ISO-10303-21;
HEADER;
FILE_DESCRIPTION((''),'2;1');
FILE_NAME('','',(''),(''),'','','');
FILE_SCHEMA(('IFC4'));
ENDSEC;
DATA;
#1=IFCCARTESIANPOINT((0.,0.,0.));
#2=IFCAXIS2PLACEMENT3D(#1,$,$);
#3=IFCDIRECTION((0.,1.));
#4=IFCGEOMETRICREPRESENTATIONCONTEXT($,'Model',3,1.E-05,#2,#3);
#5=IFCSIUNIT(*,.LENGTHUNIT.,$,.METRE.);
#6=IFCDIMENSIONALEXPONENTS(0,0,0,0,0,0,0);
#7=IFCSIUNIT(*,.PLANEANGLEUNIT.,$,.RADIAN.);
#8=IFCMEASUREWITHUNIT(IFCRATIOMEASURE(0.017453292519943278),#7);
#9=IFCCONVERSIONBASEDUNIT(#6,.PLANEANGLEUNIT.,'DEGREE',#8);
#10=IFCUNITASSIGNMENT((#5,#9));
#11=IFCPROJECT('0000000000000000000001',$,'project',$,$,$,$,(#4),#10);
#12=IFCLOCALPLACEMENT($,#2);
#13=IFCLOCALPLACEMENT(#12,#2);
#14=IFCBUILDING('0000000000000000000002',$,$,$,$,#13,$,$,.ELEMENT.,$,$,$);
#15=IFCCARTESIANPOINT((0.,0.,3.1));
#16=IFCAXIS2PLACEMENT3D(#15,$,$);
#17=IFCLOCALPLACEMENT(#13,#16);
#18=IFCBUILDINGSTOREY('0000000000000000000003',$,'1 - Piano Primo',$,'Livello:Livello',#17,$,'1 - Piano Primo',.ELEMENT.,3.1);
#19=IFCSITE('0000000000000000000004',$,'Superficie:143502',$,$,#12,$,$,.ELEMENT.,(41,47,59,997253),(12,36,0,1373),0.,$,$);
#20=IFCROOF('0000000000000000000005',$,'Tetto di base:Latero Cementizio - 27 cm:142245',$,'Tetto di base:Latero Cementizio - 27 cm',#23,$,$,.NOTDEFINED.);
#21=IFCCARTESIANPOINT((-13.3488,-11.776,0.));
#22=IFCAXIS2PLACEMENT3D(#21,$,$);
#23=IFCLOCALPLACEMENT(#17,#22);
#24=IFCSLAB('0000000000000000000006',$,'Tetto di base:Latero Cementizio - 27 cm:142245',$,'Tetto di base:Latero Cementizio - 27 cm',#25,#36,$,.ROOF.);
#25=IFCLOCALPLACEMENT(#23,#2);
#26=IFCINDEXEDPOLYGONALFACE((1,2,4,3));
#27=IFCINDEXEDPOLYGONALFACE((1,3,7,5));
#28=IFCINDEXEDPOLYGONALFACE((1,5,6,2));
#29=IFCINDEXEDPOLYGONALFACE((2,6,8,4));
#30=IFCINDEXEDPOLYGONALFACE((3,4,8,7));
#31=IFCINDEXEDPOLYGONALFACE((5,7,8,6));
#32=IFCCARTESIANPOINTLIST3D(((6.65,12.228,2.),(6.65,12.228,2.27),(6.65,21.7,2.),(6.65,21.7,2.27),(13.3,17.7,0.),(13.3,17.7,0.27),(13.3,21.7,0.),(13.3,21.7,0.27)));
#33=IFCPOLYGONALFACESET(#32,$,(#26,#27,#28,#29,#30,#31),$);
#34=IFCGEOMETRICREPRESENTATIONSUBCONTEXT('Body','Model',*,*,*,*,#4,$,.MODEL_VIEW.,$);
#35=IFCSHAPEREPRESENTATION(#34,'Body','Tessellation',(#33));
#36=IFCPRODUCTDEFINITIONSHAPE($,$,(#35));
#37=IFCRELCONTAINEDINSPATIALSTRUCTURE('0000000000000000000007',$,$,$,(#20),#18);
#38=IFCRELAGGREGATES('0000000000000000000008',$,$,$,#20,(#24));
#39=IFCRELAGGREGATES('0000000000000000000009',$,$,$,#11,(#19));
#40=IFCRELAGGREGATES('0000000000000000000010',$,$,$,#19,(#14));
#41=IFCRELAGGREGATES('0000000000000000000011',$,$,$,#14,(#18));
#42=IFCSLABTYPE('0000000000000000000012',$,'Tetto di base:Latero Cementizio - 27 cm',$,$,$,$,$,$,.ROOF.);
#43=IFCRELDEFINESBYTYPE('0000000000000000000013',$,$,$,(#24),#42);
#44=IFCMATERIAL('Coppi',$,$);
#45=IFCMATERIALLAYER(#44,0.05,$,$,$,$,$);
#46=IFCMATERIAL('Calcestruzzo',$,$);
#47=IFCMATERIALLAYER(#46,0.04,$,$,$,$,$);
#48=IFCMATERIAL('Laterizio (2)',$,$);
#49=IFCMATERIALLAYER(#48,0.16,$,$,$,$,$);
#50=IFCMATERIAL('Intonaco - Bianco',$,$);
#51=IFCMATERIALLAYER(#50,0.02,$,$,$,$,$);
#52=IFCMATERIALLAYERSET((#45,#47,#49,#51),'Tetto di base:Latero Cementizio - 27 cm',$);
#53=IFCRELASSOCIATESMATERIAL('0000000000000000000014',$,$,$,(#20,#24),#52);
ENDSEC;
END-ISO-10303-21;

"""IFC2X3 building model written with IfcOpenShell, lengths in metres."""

from ifc_helpers import new_model, entity, si_unit, converted_unit, direction, frame, origin, place, context, subcontext, project, spatial, polyline, outline, extrude, material, layer, layer_set, type_object, element, aggregate, save


model = new_model("IFC2X3")

# Units and contexts
model_context = context("Model", 3, precision=1e-05, world=origin(), true_north=direction((0.0, 1.0)))
body_context = subcontext(model_context, "Body", "Model", "MODEL_VIEW")
ifc_project = project(units=[si_unit("LENGTHUNIT", "METRE"), converted_unit("PLANEANGLEUNIT", "DEGREE", entity("IfcRatioMeasure", 0.017453292519943278), si_unit("PLANEANGLEUNIT", "RADIAN"), dimensions=[0, 0, 0, 0, 0, 0, 0])], contexts=[model_context])

# Site, building, storey
site_placement = place(None, origin())
site = spatial("IfcSite", under=ifc_project, at=site_placement, Name="Superficie:143502", CompositionType="ELEMENT", RefLatitude=(41, 47, 59, 997253), RefLongitude=(12, 36, 0, 1373), RefElevation=0.0)
building_placement = place(site_placement, origin())
building = spatial("IfcBuilding", under=site, at=building_placement, CompositionType="ELEMENT")
storey_placement = place(building_placement, frame((0.0, 0.0, 3.1)))
storey = spatial("IfcBuildingStorey", under=building, at=storey_placement, Name="1 - Piano Primo", ObjectType="Livello:Livello", LongName="1 - Piano Primo", CompositionType="ELEMENT", Elevation=3.1)

# Roof, slab
ifc_material_1 = material(Name="Coppi")
ifc_layer_1 = layer(ifc_material_1, 0.05)
ifc_material_2 = material(Name="Calcestruzzo")
ifc_layer_2 = layer(ifc_material_2, 0.04)
ifc_material_3 = material(Name="Laterizio (2)")
ifc_layer_3 = layer(ifc_material_3, 0.16)
ifc_material_4 = material(Name="Intonaco - Bianco")
ifc_layer_4 = layer(ifc_material_4, 0.02)
ifc_layer_set = layer_set([ifc_layer_1, ifc_layer_2, ifc_layer_3, ifc_layer_4], Name="Tetto di base:Latero Cementizio - 27 cm")
roof_placement = place(storey_placement, frame((-13.3488, -11.776, 0.0)))
roof = element("IfcRoof", 1, at=roof_placement, inside=storey, material=ifc_layer_set, Name="Tetto di base:Latero Cementizio - 27 cm:142245", ObjectType="Tetto di base:Latero Cementizio - 27 cm", ShapeType="NOTDEFINED")
slab_type_1 = type_object("IfcSlabType", Name="Tetto di base:Latero Cementizio - 27 cm", PredefinedType="ROOF")
slab_1_placement = place(roof_placement, origin())
slab_1 = element("IfcSlab", 2, at=slab_1_placement, type_object=slab_type_1, material=ifc_layer_set, Name="Tetto di base:Latero Cementizio - 27 cm:142245", ObjectType="Tetto di base:Latero Cementizio - 27 cm", PredefinedType="ROOF", context=body_context, shape_type="SweptSolid", body=[
    extrude(outline(polyline([(3.4721, 0.736), (3.4721, 4.736), (-3.4721, 4.736), (-3.4721, -4.736), (3.4721, 0.736)])), frame((9.975, 16.964, 1.0), z_axis=(0.288008, 0.0, 0.957628), x_axis=(0.957628, 0.0, -0.288008)), (-0.288008, 0.0, 0.957628), 0.27),
])
aggregate(roof, [slab_1])

save(model, "model.ifc")
